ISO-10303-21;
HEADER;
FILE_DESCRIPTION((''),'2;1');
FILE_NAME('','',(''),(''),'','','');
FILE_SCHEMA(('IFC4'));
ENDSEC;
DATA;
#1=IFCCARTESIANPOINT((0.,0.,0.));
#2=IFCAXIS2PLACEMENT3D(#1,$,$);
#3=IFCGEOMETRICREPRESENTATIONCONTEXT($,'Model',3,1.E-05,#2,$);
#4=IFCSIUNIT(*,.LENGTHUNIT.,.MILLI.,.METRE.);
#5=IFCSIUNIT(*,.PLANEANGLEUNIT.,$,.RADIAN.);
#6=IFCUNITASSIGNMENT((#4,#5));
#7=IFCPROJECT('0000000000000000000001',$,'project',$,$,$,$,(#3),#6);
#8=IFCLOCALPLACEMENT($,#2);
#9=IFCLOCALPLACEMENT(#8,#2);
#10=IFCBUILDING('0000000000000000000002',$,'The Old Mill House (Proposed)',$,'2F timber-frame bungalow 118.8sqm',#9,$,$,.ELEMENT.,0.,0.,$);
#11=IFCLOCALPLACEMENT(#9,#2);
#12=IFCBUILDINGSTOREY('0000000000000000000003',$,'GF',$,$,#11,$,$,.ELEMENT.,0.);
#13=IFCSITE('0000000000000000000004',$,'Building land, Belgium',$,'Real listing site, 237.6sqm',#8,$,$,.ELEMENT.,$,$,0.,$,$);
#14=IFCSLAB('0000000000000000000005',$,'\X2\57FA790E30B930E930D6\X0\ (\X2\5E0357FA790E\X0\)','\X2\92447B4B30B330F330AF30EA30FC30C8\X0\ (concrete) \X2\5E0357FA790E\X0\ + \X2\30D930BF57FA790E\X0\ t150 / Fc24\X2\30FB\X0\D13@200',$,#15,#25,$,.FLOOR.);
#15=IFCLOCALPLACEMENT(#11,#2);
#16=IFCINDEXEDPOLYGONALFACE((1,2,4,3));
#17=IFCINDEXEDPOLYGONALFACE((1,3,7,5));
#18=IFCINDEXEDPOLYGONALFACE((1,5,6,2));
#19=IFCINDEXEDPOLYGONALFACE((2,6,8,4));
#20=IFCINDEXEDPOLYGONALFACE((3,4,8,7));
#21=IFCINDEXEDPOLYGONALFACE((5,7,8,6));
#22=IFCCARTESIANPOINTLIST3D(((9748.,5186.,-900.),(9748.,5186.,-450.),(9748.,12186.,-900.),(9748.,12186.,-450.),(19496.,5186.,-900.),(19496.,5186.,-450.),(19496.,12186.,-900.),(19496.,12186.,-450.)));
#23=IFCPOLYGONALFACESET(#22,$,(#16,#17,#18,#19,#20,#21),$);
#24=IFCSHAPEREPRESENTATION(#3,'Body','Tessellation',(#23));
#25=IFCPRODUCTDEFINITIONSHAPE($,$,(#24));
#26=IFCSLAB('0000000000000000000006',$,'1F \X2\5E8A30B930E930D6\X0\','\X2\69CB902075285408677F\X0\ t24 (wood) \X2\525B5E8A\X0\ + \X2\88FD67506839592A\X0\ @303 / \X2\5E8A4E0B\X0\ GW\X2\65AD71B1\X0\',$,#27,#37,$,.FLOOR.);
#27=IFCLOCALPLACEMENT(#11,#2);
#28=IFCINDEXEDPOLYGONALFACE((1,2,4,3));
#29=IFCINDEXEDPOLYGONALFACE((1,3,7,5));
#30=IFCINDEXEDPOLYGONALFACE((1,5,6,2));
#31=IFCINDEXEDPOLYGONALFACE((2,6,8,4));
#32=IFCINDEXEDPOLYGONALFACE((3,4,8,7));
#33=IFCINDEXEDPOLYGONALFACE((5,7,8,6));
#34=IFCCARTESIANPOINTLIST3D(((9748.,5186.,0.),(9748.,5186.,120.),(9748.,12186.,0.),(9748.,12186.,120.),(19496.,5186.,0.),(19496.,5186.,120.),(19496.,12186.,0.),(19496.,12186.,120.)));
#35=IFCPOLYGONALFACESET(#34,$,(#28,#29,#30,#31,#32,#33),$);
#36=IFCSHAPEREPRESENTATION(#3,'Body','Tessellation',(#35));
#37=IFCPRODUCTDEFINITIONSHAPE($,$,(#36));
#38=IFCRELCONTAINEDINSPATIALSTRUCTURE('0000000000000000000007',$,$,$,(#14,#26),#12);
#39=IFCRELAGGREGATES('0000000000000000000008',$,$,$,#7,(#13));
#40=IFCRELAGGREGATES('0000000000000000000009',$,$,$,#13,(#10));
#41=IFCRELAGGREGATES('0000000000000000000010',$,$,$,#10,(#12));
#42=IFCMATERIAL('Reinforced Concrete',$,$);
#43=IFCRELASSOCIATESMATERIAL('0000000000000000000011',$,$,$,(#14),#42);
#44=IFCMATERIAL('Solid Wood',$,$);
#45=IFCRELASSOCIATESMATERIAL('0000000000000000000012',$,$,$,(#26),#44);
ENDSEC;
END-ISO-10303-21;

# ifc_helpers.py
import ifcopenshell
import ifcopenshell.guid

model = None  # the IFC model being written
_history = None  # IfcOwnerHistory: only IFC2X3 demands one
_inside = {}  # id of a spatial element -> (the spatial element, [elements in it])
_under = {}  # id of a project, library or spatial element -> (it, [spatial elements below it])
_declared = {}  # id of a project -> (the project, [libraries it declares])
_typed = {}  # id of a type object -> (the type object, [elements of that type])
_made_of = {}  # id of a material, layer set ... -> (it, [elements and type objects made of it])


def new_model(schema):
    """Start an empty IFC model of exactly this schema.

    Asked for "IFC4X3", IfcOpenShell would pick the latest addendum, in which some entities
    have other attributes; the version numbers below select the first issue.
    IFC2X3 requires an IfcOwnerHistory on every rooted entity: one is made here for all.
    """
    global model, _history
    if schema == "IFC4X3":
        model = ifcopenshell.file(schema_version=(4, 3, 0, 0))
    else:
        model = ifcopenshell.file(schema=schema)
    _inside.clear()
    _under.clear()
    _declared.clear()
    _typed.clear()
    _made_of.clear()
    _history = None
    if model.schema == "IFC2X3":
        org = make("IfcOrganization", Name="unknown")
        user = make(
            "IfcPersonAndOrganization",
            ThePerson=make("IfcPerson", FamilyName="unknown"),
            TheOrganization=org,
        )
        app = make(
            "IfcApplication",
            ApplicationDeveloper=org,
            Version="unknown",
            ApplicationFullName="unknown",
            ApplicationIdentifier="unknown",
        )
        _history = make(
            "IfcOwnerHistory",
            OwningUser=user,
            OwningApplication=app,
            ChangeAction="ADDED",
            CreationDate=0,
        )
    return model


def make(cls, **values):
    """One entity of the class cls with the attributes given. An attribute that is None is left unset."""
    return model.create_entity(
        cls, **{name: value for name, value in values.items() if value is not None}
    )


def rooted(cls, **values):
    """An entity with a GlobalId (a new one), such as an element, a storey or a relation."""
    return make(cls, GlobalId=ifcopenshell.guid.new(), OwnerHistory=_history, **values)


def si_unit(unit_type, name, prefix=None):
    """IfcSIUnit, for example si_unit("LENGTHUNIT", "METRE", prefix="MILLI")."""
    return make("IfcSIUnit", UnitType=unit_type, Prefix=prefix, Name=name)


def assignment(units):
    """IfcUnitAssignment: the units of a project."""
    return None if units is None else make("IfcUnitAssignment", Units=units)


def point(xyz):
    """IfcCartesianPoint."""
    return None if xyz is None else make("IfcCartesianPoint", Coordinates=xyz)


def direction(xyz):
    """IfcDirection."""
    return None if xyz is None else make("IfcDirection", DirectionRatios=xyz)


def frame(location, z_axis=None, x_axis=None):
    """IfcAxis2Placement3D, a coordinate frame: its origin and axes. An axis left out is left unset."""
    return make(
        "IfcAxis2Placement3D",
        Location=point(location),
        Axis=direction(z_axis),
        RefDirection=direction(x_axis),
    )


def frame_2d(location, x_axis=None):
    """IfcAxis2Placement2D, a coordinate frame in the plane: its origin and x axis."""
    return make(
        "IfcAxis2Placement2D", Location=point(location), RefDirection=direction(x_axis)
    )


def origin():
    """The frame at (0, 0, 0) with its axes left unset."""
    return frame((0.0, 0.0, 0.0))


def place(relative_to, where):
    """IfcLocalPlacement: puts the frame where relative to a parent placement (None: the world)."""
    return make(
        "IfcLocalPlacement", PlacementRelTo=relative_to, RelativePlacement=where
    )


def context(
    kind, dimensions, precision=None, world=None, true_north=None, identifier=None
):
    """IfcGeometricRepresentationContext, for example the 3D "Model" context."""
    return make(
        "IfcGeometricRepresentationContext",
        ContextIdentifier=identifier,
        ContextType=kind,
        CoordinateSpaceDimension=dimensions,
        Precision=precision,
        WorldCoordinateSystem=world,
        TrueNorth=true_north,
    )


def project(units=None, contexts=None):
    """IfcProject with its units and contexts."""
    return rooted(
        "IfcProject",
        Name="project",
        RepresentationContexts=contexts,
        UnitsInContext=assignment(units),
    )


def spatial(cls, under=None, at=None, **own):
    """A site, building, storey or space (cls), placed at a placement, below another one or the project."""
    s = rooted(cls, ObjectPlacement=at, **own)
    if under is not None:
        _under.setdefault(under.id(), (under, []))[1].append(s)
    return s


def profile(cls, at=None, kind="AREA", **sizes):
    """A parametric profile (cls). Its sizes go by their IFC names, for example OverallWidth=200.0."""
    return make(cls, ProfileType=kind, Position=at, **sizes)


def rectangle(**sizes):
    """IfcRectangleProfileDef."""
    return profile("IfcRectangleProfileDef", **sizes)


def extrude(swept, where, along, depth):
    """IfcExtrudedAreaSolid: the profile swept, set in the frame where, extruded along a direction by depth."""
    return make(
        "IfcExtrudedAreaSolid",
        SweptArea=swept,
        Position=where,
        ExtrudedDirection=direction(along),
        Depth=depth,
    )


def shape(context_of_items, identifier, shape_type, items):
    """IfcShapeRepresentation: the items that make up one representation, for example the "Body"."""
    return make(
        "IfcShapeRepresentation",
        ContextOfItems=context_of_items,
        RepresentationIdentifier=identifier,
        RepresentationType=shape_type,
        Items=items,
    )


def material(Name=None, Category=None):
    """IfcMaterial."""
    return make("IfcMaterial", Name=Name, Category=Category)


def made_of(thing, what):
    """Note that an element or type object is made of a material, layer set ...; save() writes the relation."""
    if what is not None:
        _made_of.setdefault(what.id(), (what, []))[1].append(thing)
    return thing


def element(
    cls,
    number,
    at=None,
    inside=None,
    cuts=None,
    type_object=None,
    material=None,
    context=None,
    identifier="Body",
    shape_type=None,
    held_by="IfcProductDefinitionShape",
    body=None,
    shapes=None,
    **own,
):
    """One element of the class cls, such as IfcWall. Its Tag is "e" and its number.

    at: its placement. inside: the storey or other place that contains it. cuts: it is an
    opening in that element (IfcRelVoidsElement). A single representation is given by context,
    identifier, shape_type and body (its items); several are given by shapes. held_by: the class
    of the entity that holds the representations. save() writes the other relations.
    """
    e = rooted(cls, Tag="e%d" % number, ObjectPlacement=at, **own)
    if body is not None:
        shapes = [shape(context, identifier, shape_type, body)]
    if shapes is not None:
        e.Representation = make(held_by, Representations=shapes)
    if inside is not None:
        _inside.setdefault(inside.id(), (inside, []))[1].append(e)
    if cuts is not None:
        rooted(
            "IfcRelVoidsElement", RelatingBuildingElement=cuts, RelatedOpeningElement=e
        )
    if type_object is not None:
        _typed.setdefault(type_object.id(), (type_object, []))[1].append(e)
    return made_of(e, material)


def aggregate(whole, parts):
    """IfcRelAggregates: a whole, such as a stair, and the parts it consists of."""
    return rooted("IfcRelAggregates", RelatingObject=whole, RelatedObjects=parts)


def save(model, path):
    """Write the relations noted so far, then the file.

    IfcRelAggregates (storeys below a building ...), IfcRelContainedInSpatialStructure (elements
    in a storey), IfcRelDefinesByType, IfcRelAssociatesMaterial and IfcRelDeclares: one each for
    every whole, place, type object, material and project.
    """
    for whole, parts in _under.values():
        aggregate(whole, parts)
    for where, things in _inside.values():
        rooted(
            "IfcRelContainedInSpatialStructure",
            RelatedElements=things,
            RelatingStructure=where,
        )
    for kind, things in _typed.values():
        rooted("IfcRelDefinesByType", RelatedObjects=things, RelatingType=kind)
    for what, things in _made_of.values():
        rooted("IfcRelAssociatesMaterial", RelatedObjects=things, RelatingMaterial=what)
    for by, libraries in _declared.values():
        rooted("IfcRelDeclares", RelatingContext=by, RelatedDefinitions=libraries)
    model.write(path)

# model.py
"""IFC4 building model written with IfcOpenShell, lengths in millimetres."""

from ifc_helpers import new_model, si_unit, frame, frame_2d, origin, place, context, project, spatial, rectangle, extrude, material, element, save


model = new_model("IFC4")

# Units and contexts
model_context = context("Model", 3, precision=1e-05, world=origin())
ifc_project = project(units=[si_unit("LENGTHUNIT", "METRE", prefix="MILLI"), si_unit("PLANEANGLEUNIT", "RADIAN")], contexts=[model_context])

# Site, building, storey
site_placement = place(None, origin())
site = spatial("IfcSite", under=ifc_project, at=site_placement, Name="Building land, Belgium", ObjectType="Real listing site, 237.6sqm", CompositionType="ELEMENT", RefElevation=0.0)
building_placement = place(site_placement, origin())
building = spatial("IfcBuilding", under=site, at=building_placement, Name="The Old Mill House (Proposed)", ObjectType="2F timber-frame bungalow 118.8sqm", CompositionType="ELEMENT", ElevationOfRefHeight=0.0, ElevationOfTerrain=0.0)
storey_placement = place(building_placement, origin())
storey = spatial("IfcBuildingStorey", under=building, at=storey_placement, Name="GF", CompositionType="ELEMENT", Elevation=0.0)

# Slabs
ifc_material_1 = material(Name="Reinforced Concrete")
slab_1_placement = place(storey_placement, frame((4874.0, 2593.0, -450.0)))
element("IfcSlab", 1, at=slab_1_placement, inside=storey, material=ifc_material_1, Name="基礎スラブ (布基礎)", Description="鉄筋コンクリート (concrete) 布基礎 + ベタ基礎 t150 / Fc24・D13@200", PredefinedType="FLOOR", context=model_context, shape_type="SweptSolid", body=[
    extrude(rectangle(XDim=9748.0, YDim=7000.0, at=frame_2d((4874.0, 3500.0))), frame((4874.0, 2593.0, -450.0)), (0.0, 0.0, 1.0), 450.0),
])
ifc_material_2 = material(Name="Solid Wood")
slab_2_placement = place(storey_placement, frame((4874.0, 2593.0, 0.0)))
element("IfcSlab", 2, at=slab_2_placement, inside=storey, material=ifc_material_2, Name="1F 床スラブ", Description="構造用合板 t24 (wood) 剛床 + 製材根太 @303 / 床下 GW断熱", PredefinedType="FLOOR", context=model_context, shape_type="SweptSolid", body=[
    extrude(rectangle(XDim=9748.0, YDim=7000.0, at=frame_2d((4874.0, 3500.0))), frame((4874.0, 2593.0, 0.0)), (0.0, 0.0, 1.0), 120.0),
])

save(model, "model.ifc")
